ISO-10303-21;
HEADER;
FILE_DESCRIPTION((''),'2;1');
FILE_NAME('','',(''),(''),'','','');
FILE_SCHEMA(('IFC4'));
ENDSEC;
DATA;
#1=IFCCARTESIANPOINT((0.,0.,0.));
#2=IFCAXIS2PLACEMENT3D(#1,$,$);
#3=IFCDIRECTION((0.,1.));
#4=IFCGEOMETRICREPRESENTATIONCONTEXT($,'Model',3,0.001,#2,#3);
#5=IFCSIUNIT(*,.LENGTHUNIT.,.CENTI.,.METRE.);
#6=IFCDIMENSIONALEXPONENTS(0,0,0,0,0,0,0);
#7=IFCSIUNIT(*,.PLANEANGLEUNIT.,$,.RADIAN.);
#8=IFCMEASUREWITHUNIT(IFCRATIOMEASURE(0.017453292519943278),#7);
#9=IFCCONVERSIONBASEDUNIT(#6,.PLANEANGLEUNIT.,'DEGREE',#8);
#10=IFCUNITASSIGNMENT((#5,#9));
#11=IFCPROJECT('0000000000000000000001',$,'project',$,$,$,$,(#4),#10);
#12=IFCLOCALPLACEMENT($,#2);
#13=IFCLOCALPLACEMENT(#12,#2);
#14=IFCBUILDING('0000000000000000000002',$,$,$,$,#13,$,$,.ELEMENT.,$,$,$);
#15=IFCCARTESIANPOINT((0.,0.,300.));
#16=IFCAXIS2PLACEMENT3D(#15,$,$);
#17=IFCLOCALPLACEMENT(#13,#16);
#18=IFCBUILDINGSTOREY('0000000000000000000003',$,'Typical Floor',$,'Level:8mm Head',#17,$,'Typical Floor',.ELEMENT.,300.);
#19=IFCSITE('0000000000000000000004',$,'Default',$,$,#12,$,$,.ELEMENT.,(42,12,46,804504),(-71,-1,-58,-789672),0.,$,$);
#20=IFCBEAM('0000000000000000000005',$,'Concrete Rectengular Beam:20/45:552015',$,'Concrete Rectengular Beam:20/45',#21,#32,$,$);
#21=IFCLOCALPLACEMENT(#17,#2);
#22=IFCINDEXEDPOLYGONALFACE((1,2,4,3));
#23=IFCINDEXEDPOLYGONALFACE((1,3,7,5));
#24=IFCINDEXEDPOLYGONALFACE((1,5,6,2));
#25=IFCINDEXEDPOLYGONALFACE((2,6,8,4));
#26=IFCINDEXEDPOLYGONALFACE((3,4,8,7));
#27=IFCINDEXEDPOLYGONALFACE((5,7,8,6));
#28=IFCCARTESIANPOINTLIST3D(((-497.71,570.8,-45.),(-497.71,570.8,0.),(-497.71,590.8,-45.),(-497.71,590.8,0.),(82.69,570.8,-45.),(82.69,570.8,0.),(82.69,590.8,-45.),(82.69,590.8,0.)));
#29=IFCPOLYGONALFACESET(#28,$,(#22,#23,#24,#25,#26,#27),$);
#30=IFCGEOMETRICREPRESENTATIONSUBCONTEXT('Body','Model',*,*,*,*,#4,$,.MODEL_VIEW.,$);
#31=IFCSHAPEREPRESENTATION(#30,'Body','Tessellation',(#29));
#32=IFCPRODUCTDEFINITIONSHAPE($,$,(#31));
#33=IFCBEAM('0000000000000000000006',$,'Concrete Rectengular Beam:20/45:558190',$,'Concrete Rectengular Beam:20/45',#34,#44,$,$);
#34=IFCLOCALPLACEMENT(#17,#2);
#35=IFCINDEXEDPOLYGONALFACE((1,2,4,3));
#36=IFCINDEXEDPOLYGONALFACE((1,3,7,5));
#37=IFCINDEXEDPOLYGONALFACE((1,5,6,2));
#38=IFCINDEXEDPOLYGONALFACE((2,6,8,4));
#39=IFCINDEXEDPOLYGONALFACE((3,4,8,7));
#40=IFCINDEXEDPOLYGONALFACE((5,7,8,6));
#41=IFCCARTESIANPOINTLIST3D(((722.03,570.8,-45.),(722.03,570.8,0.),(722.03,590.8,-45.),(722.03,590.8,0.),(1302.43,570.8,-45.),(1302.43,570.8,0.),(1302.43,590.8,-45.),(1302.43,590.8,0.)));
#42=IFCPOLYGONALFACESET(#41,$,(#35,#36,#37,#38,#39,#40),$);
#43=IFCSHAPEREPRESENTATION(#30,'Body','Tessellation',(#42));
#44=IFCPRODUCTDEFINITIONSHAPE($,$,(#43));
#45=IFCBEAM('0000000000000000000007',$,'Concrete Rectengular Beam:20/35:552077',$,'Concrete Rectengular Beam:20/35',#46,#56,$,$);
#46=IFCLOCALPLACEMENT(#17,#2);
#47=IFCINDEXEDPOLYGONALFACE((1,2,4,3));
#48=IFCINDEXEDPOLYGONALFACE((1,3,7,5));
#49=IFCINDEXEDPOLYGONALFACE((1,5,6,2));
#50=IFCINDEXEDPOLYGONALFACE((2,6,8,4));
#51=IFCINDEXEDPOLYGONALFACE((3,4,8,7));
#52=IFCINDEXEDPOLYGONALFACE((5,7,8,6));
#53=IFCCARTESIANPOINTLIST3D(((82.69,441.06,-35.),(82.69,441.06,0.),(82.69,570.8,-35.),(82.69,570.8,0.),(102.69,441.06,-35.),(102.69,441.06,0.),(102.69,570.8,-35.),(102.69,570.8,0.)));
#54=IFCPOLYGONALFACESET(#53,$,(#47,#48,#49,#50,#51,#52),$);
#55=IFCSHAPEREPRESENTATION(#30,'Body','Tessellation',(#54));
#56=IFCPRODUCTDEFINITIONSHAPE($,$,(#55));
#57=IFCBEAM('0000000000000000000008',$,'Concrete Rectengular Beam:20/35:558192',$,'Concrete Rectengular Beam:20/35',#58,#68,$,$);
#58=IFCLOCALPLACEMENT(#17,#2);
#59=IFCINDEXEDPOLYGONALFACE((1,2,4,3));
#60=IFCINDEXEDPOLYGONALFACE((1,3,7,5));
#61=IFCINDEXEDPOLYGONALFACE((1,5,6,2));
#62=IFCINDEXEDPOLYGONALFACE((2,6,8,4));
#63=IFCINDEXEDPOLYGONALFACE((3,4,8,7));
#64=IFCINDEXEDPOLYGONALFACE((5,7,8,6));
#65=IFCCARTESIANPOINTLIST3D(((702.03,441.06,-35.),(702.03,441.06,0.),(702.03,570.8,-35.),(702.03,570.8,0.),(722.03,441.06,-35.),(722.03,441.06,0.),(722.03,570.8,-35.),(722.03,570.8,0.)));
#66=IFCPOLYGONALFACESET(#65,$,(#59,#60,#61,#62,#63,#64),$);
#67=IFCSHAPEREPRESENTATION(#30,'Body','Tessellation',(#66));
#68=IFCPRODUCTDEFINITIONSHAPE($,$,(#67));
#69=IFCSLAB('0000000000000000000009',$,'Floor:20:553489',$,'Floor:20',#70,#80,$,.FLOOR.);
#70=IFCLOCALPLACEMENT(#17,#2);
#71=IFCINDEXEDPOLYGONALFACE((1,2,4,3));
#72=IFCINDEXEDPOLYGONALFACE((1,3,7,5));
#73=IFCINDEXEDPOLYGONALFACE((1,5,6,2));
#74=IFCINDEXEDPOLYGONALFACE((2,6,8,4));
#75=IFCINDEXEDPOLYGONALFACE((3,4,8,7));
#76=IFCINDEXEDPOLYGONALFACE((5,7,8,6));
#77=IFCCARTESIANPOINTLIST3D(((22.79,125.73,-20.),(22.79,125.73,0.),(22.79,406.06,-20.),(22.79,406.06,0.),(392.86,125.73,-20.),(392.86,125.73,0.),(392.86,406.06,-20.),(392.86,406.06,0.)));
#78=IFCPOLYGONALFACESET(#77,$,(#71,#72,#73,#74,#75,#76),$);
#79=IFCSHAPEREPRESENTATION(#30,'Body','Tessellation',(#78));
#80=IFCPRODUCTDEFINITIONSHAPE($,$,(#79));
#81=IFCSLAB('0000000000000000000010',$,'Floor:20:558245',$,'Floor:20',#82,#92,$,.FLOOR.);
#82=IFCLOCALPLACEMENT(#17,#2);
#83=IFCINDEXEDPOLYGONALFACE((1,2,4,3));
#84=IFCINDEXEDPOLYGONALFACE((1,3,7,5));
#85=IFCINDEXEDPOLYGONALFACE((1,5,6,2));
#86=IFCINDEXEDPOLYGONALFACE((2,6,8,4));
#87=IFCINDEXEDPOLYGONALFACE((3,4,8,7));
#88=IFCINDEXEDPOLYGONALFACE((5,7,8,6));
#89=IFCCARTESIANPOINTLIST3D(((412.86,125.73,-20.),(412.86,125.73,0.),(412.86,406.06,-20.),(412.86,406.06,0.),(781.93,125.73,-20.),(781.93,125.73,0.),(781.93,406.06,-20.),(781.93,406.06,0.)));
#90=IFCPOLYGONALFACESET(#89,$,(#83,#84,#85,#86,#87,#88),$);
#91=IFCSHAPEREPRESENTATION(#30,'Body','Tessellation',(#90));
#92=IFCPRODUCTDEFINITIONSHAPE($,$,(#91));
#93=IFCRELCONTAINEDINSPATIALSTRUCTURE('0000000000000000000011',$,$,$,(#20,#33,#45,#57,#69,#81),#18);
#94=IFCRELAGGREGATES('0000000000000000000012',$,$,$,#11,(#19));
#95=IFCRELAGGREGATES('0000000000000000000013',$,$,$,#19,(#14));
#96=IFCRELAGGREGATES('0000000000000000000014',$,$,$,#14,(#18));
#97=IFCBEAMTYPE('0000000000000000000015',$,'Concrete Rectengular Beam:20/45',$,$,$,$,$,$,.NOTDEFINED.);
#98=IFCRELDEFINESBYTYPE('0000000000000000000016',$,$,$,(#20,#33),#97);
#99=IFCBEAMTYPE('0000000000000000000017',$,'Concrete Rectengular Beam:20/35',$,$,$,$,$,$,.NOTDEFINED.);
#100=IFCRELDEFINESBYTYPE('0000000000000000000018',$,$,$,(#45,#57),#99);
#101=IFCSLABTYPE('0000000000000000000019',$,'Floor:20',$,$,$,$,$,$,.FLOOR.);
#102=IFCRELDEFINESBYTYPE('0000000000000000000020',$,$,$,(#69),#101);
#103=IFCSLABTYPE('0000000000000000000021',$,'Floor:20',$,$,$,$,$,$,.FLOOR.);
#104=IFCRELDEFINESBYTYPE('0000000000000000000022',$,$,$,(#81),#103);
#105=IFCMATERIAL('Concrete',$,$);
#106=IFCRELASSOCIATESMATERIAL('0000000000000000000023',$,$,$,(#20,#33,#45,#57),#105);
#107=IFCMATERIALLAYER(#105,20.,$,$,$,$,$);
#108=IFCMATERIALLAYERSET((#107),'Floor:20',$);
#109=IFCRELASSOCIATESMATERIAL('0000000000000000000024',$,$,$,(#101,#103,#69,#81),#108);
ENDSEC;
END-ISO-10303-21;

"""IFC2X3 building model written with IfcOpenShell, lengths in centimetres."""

from ifc_helpers import new_model, entity, si_unit, converted_unit, direction, frame, frame_2d, origin, place, context, subcontext, project, spatial, rectangle, extrude, material, layer, layer_set, layer_usage, type_object, element, save


model = new_model("IFC2X3")

# Units and contexts
model_context = context("Model", 3, precision=0.001, world=origin(), true_north=direction((0.0, 1.0)))
body_context = subcontext(model_context, "Body", "Model", "MODEL_VIEW")
ifc_project = project(units=[si_unit("LENGTHUNIT", "METRE", prefix="CENTI"), converted_unit("PLANEANGLEUNIT", "DEGREE", entity("IfcRatioMeasure", 0.017453292519943278), si_unit("PLANEANGLEUNIT", "RADIAN"), dimensions=[0, 0, 0, 0, 0, 0, 0])], contexts=[model_context])

# Site, building, storey
site_placement = place(None, origin())
site = spatial("IfcSite", under=ifc_project, at=site_placement, Name="Default", CompositionType="ELEMENT", RefLatitude=(42, 12, 46, 804504), RefLongitude=(-71, -1, -58, -789672), RefElevation=0.0)
building_placement = place(site_placement, origin())
building = spatial("IfcBuilding", under=site, at=building_placement, CompositionType="ELEMENT")
storey_placement = place(building_placement, frame((0.0, 0.0, 300.0)))
storey = spatial("IfcBuildingStorey", under=building, at=storey_placement, Name="Typical Floor", ObjectType="Level:8mm Head", LongName="Typical Floor", CompositionType="ELEMENT", Elevation=300.0)

# Beams
ifc_material = material(Name="Concrete")
beam_type_1 = type_object("IfcBeamType", Name="Concrete Rectengular Beam:20/45", PredefinedType="NOTDEFINED")
beam_1_placement = place(storey_placement, frame((-507.71, 580.8, 0.0)))
element("IfcBeam", 1, at=beam_1_placement, inside=storey, type_object=beam_type_1, material=ifc_material, Name="Concrete Rectengular Beam:20/45:552015", ObjectType="Concrete Rectengular Beam:20/45", context=body_context, shape_type="SweptSolid", body=[
    extrude(rectangle(XDim=45.0, YDim=20.0, at=frame_2d((0.0, 0.0), x_axis=(1.0, 0.0))), frame((10.0, 0.0, -22.5), z_axis=(1.0, 0.0, 0.0), x_axis=(0.0, 0.0, -1.0)), (0.0, 0.0, 1.0), 580.4),
])
beam_2_placement = place(storey_placement, frame((1312.43, 580.8, 0.0), z_axis=(0.0, 0.0, 1.0), x_axis=(-1.0, 0.0, 0.0)))
element("IfcBeam", 2, at=beam_2_placement, inside=storey, type_object=beam_type_1, material=ifc_material, Name="Concrete Rectengular Beam:20/45:558190", ObjectType="Concrete Rectengular Beam:20/45", context=body_context, shape_type="SweptSolid", body=[
    extrude(rectangle(XDim=45.0, YDim=20.0, at=frame_2d((0.0, 0.0), x_axis=(1.0, 0.0))), frame((10.0, 0.0, -22.5), z_axis=(1.0, 0.0, 0.0), x_axis=(0.0, 0.0, -1.0)), (0.0, 0.0, 1.0), 580.4),
])
beam_type_2 = type_object("IfcBeamType", Name="Concrete Rectengular Beam:20/35", PredefinedType="NOTDEFINED")
beam_3_placement = place(storey_placement, frame((92.69, 580.8, 0.0), z_axis=(0.0, 0.0, 1.0), x_axis=(0.0, -1.0, 0.0)))
element("IfcBeam", 3, at=beam_3_placement, inside=storey, type_object=beam_type_2, material=ifc_material, Name="Concrete Rectengular Beam:20/35:552077", ObjectType="Concrete Rectengular Beam:20/35", context=body_context, shape_type="SweptSolid", body=[
    extrude(rectangle(XDim=35.0, YDim=20.0, at=frame_2d((0.0, 0.0), x_axis=(1.0, 0.0))), frame((10.0, 0.0, -17.5), z_axis=(1.0, 0.0, 0.0), x_axis=(0.0, 0.0, -1.0)), (0.0, 0.0, 1.0), 129.74),
])
beam_4_placement = place(storey_placement, frame((712.03, 580.8, 0.0), z_axis=(0.0, 0.0, 1.0), x_axis=(0.0, -1.0, 0.0)))
element("IfcBeam", 4, at=beam_4_placement, inside=storey, type_object=beam_type_2, material=ifc_material, Name="Concrete Rectengular Beam:20/35:558192", ObjectType="Concrete Rectengular Beam:20/35", context=body_context, shape_type="SweptSolid", body=[
    extrude(rectangle(XDim=35.0, YDim=20.0, at=frame_2d((0.0, 0.0), x_axis=(1.0, 0.0))), frame((10.0, 0.0, -17.5), z_axis=(1.0, 0.0, 0.0), x_axis=(0.0, 0.0, -1.0)), (0.0, 0.0, 1.0), 129.74),
])

# Slabs
ifc_layer = layer(ifc_material, 20.0)
ifc_layer_set = layer_set([ifc_layer], Name="Floor:20")
ifc_layer_usage_1 = layer_usage(ifc_layer_set, "AXIS3", "POSITIVE", 0.0)
slab_type_1 = type_object("IfcSlabType", Name="Floor:20", PredefinedType="FLOOR", material=ifc_layer_set)
slab_1_placement = place(storey_placement, origin())
element("IfcSlab", 5, at=slab_1_placement, inside=storey, type_object=slab_type_1, material=ifc_layer_usage_1, Name="Floor:20:553489", ObjectType="Floor:20", PredefinedType="FLOOR", context=body_context, shape_type="SweptSolid", body=[
    extrude(rectangle(XDim=280.33, YDim=370.07, at=frame_2d((0.0, 0.0), x_axis=(1.0, 0.0))), frame((207.82, 265.9, 0.0), z_axis=(0.0, 0.0, -1.0), x_axis=(0.0, 1.0, 0.0)), (0.0, 0.0, 1.0), 20.0),
])
ifc_layer_usage_2 = layer_usage(ifc_layer_set, "AXIS3", "POSITIVE", 0.0)
slab_type_2 = type_object("IfcSlabType", Name="Floor:20", PredefinedType="FLOOR", material=ifc_layer_set)
slab_2_placement = place(storey_placement, origin())
element("IfcSlab", 6, at=slab_2_placement, inside=storey, type_object=slab_type_2, material=ifc_layer_usage_2, Name="Floor:20:558245", ObjectType="Floor:20", PredefinedType="FLOOR", context=body_context, shape_type="SweptSolid", body=[
    extrude(rectangle(XDim=280.33, YDim=369.07, at=frame_2d((0.0, 0.0), x_axis=(1.0, 0.0))), frame((597.39, 265.9, 0.0), z_axis=(0.0, 0.0, -1.0), x_axis=(0.0, 1.0, 0.0)), (0.0, 0.0, 1.0), 20.0),
])

save(model, "model.ifc")
